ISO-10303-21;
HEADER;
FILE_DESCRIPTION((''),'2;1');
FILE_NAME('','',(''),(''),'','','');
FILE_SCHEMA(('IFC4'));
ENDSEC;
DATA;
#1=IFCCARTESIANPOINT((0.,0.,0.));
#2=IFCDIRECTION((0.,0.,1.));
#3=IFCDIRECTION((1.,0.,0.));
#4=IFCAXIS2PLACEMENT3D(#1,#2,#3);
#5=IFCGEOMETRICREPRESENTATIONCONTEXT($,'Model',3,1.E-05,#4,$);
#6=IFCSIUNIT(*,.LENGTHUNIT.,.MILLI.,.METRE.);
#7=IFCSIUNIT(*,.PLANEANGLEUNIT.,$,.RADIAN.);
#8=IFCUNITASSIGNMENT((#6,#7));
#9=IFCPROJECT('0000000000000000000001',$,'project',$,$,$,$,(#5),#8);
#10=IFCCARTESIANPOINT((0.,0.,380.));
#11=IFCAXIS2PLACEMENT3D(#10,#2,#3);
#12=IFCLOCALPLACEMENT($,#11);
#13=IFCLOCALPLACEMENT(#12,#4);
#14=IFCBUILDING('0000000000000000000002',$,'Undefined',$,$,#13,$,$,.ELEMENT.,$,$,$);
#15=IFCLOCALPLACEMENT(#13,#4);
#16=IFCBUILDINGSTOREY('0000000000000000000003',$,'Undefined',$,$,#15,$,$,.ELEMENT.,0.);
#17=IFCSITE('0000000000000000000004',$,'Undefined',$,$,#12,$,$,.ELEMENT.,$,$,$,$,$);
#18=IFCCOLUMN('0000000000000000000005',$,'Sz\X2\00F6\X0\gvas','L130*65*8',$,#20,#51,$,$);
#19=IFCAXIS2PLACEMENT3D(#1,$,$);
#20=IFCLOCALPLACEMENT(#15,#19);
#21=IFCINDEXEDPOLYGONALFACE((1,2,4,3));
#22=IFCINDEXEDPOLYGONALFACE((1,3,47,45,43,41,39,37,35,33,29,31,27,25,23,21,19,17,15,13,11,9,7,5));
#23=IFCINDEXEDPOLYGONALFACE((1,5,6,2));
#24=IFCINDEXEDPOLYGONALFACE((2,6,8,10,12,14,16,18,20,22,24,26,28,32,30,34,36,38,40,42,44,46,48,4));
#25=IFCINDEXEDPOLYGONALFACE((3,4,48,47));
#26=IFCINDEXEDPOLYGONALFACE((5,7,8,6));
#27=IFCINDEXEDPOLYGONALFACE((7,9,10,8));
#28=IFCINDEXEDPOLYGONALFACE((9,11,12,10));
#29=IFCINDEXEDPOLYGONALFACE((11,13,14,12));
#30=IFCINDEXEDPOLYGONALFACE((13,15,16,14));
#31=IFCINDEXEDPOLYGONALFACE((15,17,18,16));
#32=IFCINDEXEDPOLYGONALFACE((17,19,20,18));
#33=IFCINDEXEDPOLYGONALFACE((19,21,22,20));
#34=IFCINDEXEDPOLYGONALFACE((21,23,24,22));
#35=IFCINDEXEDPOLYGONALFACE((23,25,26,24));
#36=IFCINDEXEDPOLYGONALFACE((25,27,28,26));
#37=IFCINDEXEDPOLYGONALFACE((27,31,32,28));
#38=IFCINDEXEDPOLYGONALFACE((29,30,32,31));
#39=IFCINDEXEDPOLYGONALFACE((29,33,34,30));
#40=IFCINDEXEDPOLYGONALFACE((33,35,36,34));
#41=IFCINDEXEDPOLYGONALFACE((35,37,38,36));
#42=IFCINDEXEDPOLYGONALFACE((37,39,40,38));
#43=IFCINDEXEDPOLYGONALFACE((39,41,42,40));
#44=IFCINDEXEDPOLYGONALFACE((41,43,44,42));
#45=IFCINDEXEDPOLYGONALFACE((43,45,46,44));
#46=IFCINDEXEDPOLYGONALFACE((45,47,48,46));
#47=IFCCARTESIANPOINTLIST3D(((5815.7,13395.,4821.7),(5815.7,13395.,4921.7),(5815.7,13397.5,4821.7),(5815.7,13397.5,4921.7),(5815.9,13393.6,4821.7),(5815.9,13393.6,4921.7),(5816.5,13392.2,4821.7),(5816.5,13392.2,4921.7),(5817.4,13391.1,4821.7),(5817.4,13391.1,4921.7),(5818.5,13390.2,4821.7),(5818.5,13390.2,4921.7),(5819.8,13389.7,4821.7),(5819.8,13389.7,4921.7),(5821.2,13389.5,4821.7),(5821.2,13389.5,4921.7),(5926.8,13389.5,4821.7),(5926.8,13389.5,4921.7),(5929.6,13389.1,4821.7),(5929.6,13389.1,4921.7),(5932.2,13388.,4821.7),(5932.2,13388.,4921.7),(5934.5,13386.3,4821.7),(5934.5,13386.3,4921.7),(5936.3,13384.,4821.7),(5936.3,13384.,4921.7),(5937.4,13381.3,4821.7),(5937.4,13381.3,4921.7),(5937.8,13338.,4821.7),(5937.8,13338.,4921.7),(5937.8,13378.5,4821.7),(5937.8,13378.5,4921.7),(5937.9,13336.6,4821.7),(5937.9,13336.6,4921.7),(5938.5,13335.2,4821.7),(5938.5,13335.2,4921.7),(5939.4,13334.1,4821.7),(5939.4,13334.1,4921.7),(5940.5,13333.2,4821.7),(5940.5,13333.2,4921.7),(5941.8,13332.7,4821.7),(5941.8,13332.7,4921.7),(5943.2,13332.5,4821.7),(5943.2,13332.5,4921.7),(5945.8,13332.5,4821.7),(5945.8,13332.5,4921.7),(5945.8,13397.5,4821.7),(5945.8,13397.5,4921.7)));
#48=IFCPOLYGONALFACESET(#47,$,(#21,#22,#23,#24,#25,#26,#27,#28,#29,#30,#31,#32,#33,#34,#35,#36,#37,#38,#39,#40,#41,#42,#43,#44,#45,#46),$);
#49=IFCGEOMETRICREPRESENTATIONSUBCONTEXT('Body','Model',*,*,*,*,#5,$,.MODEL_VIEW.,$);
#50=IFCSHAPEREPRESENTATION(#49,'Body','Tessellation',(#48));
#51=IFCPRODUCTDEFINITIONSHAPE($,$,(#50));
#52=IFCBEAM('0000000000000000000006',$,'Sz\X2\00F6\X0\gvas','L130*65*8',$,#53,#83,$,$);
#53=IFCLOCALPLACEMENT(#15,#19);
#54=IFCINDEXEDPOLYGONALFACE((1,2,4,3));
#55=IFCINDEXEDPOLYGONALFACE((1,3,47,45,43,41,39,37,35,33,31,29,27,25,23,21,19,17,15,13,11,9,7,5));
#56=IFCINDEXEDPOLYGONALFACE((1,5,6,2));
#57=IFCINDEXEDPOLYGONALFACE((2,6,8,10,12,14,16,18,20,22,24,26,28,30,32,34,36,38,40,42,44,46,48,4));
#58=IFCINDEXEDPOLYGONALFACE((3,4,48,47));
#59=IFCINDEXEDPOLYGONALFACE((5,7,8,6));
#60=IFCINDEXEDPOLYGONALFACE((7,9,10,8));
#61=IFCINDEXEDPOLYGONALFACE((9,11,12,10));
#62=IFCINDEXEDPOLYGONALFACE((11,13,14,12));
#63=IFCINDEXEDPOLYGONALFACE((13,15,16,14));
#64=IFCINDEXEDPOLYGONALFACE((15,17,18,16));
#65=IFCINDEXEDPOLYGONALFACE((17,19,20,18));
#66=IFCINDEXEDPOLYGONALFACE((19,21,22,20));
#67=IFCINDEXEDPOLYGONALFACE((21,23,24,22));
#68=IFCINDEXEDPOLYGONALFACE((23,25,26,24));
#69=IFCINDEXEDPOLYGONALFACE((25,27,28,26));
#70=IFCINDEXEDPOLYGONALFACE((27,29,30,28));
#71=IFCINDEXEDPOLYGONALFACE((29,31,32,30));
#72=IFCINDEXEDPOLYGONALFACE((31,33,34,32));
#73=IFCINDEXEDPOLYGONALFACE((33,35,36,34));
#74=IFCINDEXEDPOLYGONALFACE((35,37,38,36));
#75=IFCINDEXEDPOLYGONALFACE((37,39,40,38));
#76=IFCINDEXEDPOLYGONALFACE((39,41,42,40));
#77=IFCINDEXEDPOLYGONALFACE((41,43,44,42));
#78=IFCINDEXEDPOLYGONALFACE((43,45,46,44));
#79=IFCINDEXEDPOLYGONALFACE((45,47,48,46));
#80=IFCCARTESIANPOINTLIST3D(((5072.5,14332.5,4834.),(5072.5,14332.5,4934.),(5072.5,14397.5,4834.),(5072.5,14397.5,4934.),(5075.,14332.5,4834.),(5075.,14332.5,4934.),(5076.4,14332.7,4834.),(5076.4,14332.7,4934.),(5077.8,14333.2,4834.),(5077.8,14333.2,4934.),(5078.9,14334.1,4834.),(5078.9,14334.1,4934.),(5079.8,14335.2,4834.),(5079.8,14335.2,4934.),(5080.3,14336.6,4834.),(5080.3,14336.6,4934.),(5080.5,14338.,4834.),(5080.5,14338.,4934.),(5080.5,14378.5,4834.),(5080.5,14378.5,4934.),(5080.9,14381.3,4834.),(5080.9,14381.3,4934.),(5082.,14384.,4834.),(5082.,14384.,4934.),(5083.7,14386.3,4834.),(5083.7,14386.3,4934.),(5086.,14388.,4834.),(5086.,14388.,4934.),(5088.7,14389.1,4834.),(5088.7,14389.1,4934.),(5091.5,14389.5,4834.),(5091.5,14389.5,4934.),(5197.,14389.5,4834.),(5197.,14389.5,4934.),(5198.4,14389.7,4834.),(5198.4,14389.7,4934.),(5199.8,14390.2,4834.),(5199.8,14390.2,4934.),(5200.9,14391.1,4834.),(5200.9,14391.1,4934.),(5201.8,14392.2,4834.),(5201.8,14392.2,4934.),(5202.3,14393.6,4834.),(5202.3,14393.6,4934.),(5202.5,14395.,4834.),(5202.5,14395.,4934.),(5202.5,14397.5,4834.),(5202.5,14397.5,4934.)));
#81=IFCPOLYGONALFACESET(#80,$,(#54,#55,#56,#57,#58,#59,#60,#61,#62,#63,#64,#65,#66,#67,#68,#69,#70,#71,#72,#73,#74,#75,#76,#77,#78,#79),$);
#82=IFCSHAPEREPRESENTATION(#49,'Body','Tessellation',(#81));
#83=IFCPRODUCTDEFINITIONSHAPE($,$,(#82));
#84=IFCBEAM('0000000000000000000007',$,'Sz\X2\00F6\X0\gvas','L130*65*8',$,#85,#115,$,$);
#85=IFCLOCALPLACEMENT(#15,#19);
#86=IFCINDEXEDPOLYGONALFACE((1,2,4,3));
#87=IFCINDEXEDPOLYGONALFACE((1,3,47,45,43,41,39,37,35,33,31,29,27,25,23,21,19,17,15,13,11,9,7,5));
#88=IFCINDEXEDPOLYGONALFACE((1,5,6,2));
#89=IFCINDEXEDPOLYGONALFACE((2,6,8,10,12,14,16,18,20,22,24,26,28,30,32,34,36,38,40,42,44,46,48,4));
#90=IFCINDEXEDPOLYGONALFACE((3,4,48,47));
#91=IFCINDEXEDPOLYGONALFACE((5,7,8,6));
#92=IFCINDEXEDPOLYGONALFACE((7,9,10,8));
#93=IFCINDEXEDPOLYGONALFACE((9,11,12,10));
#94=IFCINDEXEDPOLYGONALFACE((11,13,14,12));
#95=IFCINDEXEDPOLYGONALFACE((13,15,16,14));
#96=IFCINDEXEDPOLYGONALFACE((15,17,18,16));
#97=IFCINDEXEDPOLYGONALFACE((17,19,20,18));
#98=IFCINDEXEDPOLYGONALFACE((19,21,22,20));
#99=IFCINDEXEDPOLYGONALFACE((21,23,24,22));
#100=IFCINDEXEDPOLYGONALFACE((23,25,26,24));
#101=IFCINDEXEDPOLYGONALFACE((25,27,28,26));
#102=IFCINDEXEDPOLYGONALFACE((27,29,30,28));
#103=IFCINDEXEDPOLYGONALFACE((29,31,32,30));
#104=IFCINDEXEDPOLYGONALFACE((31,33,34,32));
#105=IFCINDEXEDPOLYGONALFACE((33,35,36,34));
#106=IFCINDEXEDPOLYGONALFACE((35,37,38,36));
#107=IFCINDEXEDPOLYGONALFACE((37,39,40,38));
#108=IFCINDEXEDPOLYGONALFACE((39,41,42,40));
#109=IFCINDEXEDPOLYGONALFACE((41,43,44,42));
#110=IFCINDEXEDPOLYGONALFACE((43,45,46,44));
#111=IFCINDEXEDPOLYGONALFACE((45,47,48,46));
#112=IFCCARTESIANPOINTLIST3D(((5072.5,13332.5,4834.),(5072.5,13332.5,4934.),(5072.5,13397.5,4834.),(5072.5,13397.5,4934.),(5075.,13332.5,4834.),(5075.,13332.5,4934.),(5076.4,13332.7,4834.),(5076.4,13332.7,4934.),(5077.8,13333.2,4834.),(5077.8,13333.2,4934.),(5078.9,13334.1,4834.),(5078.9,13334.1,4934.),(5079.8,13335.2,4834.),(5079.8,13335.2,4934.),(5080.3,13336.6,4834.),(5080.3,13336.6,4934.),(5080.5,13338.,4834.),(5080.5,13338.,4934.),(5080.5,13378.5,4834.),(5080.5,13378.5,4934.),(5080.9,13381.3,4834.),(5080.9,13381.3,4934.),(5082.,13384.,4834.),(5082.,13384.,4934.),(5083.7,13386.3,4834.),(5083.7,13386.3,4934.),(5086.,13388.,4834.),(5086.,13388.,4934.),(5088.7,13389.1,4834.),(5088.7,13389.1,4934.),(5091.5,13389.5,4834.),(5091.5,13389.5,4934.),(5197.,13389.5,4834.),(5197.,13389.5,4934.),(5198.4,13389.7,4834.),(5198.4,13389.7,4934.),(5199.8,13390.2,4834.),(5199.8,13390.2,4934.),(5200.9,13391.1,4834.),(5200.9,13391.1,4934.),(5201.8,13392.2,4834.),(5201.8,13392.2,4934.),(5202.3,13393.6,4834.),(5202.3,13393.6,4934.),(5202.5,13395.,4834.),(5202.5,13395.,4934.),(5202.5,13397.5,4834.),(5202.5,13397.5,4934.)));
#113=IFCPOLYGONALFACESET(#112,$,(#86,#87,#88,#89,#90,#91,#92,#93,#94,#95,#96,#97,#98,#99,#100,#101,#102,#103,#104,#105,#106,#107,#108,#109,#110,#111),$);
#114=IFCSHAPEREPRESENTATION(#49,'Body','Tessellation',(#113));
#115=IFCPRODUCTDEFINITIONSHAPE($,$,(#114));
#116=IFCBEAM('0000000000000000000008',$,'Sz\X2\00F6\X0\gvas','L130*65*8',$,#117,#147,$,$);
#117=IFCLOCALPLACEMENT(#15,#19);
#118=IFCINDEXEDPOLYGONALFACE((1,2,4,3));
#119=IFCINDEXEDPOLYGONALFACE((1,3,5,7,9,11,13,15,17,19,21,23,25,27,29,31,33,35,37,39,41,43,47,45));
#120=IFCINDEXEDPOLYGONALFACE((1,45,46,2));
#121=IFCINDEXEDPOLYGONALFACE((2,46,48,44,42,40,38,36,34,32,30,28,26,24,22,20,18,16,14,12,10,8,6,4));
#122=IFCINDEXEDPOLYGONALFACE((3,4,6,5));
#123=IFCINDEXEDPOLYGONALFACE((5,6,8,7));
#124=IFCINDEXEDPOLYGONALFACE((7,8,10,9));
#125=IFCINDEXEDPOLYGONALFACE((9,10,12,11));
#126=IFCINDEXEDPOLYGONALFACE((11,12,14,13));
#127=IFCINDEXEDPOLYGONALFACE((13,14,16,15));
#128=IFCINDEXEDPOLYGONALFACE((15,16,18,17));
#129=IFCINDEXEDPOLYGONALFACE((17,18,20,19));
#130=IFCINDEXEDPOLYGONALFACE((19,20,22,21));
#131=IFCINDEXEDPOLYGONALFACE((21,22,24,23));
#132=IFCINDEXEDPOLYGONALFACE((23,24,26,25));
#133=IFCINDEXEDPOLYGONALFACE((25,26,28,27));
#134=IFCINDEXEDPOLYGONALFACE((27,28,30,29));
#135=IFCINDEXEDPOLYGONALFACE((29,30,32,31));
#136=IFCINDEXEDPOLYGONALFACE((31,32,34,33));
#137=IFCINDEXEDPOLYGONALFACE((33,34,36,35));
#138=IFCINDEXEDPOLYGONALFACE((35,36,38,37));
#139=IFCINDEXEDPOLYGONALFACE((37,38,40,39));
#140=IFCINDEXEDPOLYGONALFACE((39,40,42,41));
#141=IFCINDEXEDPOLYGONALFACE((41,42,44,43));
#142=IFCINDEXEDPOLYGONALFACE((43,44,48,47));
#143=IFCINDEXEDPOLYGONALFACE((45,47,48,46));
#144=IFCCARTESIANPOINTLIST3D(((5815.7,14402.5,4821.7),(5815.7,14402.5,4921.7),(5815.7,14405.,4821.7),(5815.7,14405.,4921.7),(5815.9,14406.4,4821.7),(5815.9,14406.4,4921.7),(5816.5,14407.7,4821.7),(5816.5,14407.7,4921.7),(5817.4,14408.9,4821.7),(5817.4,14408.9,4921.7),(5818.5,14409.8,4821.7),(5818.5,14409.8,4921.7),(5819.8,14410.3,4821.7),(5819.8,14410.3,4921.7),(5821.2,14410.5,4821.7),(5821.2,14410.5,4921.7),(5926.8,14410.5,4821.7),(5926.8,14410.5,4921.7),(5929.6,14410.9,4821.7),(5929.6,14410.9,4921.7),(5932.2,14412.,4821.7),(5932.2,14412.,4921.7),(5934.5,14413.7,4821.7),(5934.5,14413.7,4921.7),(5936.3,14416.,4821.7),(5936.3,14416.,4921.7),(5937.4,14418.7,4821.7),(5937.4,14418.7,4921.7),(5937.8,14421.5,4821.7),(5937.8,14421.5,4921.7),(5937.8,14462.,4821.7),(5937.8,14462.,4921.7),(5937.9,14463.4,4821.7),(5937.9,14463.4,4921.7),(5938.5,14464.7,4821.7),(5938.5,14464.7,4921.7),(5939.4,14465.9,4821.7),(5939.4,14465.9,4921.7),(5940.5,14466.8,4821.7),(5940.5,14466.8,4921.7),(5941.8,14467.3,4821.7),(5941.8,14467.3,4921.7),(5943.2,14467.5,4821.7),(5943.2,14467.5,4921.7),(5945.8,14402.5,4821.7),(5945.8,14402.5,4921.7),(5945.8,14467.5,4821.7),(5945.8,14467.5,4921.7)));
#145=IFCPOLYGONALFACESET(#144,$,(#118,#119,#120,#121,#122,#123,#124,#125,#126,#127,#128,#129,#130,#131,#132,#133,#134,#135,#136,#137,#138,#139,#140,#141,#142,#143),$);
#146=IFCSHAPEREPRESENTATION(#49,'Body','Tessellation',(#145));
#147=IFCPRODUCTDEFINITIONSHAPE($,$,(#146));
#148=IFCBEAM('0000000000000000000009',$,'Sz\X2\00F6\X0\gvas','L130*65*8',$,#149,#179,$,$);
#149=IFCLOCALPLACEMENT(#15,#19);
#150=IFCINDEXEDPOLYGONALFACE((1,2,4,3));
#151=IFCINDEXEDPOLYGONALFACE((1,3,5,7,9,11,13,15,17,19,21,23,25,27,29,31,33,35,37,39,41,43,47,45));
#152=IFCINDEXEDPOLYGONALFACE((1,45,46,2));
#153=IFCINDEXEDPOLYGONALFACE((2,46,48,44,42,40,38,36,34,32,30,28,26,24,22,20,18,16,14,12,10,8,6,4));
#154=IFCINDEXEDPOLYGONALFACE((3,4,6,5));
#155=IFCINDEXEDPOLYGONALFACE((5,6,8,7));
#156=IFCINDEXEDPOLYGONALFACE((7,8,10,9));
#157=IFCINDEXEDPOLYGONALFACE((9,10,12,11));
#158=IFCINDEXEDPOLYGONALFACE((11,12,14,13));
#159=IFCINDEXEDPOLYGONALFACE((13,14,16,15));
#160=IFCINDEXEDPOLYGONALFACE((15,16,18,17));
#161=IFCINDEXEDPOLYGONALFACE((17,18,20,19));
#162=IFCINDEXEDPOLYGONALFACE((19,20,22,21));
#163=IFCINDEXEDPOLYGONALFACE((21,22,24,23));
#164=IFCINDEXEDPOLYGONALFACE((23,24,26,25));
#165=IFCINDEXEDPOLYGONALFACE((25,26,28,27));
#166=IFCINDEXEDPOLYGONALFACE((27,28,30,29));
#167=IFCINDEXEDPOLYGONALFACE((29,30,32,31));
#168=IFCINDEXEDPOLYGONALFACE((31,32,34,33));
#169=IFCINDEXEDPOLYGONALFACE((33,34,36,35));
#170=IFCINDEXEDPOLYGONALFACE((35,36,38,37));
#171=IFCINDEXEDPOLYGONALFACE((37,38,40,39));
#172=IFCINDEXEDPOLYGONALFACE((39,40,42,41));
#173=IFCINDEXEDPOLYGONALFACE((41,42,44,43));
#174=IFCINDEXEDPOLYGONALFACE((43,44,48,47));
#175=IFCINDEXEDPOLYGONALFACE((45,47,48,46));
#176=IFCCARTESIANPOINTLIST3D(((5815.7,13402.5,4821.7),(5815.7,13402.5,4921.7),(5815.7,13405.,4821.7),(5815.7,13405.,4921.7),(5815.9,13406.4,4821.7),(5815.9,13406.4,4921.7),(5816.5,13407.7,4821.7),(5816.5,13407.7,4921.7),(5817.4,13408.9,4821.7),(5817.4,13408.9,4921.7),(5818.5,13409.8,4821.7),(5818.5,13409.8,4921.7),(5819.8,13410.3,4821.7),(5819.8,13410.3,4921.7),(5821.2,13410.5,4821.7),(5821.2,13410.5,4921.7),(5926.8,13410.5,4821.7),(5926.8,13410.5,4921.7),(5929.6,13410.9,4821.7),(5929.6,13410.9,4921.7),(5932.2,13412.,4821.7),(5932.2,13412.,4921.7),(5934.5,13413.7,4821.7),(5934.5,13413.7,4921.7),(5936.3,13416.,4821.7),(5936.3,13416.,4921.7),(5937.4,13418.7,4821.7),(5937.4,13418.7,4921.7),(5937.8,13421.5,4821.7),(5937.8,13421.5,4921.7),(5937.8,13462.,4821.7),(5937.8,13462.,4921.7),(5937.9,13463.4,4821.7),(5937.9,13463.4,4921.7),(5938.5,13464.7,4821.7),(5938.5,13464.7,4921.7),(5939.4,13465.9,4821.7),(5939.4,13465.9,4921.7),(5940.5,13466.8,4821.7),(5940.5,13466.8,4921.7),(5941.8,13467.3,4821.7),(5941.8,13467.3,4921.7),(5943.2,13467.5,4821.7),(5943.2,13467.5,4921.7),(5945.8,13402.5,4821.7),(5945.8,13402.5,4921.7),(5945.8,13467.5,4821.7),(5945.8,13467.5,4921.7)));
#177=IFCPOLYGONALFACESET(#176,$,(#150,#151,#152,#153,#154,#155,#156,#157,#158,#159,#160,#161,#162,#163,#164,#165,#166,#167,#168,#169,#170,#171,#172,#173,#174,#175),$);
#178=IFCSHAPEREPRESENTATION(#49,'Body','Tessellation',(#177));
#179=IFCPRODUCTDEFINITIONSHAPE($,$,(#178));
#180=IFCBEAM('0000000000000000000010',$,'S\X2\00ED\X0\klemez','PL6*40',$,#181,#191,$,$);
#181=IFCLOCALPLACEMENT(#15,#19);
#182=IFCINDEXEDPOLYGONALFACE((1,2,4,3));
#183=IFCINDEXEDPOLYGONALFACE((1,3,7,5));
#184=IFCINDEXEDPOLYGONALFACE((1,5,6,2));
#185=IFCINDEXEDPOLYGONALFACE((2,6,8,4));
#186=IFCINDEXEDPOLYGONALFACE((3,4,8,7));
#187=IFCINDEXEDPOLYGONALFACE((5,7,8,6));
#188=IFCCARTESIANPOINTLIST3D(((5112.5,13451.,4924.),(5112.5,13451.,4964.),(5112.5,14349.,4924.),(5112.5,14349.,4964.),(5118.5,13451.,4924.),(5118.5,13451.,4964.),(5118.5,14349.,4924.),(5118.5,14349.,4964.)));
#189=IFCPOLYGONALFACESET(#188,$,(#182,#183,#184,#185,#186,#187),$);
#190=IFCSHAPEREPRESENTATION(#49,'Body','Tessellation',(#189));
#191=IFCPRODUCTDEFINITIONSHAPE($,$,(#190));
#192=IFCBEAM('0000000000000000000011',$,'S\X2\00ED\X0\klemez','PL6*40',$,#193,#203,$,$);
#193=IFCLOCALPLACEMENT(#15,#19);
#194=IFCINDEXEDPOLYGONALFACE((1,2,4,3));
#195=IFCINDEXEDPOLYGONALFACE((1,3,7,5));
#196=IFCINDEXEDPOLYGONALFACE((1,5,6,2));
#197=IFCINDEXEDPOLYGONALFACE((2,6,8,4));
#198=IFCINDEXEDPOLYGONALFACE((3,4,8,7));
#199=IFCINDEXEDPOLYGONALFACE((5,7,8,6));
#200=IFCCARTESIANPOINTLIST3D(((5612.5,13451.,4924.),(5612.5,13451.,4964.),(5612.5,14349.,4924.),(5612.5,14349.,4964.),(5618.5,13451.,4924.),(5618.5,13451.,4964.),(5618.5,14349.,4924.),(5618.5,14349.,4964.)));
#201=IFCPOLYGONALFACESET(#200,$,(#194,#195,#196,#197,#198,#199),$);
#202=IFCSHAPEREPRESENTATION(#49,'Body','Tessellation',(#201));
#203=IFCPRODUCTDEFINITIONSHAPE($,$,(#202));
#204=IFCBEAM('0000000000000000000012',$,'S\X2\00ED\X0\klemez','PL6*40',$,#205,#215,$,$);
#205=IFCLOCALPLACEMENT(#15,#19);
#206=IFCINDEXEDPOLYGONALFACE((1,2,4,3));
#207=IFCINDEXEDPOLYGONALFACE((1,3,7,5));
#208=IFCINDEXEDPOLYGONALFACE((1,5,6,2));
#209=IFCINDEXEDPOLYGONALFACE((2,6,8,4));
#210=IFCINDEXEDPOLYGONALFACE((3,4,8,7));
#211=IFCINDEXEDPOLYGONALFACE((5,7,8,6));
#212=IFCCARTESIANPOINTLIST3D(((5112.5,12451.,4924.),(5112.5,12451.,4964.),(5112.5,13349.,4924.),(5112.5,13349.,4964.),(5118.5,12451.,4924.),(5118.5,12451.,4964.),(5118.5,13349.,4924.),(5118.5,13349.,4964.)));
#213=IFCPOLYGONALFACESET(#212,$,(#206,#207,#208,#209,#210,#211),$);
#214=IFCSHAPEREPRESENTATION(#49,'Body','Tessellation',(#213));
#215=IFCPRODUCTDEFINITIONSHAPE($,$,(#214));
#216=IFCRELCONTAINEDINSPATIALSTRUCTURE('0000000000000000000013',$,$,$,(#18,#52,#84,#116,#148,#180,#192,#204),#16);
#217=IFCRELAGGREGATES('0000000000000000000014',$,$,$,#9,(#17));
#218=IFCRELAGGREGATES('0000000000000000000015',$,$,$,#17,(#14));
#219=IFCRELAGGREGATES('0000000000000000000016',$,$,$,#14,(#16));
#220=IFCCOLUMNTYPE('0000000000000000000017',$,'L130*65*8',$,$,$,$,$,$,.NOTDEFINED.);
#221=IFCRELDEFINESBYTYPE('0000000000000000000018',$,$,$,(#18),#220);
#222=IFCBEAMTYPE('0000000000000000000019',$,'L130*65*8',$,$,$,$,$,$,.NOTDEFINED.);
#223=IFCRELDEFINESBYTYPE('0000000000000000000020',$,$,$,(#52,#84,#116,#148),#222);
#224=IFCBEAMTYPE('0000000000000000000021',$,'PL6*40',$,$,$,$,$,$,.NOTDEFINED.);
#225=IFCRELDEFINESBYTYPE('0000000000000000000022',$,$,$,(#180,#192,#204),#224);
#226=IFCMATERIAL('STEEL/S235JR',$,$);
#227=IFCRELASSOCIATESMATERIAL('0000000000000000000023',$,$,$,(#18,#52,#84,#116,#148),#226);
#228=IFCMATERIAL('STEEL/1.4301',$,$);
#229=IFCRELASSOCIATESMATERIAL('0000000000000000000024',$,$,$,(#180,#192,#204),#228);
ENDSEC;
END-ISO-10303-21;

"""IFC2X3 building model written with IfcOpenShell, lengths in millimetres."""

from ifc_helpers import new_model, si_unit, frame, origin_with_axes, origin_2d_with_axis, place, context, subcontext, project, spatial, rectangle, l_section, extrude, material, type_object, element, save


model = new_model("IFC2X3")

# Units and contexts
model_context = context("Model", 3, precision=1e-05, world=origin_with_axes())
body_context = subcontext(model_context, "Body", "Model", "MODEL_VIEW")
ifc_project = project(units=[si_unit("LENGTHUNIT", "METRE", prefix="MILLI"), si_unit("PLANEANGLEUNIT", "RADIAN")], contexts=[model_context])

# Site, building, storey
site_placement = place(None, frame((0.0, 0.0, 380.0), z_axis=(0.0, 0.0, 1.0), x_axis=(1.0, 0.0, 0.0)))
site = spatial("IfcSite", under=ifc_project, at=site_placement, Name="Undefined", CompositionType="ELEMENT")
building_placement = place(site_placement, origin_with_axes())
building = spatial("IfcBuilding", under=site, at=building_placement, Name="Undefined", CompositionType="ELEMENT")
storey_placement = place(building_placement, origin_with_axes())
storey = spatial("IfcBuildingStorey", under=building, at=storey_placement, Name="Undefined", CompositionType="ELEMENT", Elevation=0.0)

# Column
ifc_material_1 = material(Name="STEEL/S235JR")
column_type_1 = type_object("IfcColumnType", Name="L130*65*8", PredefinedType="NOTDEFINED")
for number, where, z_axis, x_axis, name in (
    (1, (5880.8, 13365.0, 4821.7), (0.0, 0.0, 1.0), (-1.0, 0.0, 0.0), "Szögvas"),
):
    element("IfcColumn", number, at=place(storey_placement, frame(where, z_axis=z_axis, x_axis=x_axis)), inside=storey, type_object=column_type_1, material=ifc_material_1, Name=name, Description="L130*65*8", context=body_context, shape_type="SweptSolid", body=[
        extrude(l_section(Depth=130.0, Width=65.0, Thickness=8.0, FilletRadius=11.0, EdgeRadius=5.5, at=origin_2d_with_axis()), frame((0.0, 0.0, 100.0), z_axis=(0.0, 0.0, -1.0), x_axis=(0.0, 1.0, 0.0)), (0.0, 0.0, 1.0), 100.0),
    ])

# Beams
beam_type_1 = type_object("IfcBeamType", Name="L130*65*8", PredefinedType="NOTDEFINED")
for number, where, z_axis, x_axis, name in (
    (2, (5137.5, 14365.0, 4934.0), (1.0, 0.0, 0.0), (0.0, 0.0, -1.0), "Szögvas"),
    (3, (5137.5, 13365.0, 4934.0), (1.0, 0.0, 0.0), (0.0, 0.0, -1.0), "Szögvas"),
    (4, (5880.8, 14435.0, 4921.7), (-1.0, 0.0, 0.0), (0.0, 0.0, -1.0), "Szögvas"),
    (5, (5880.8, 13435.0, 4921.7), (-1.0, 0.0, 0.0), (0.0, 0.0, -1.0), "Szögvas"),
):
    element("IfcBeam", number, at=place(storey_placement, frame(where, z_axis=z_axis, x_axis=x_axis)), inside=storey, type_object=beam_type_1, material=ifc_material_1, Name=name, Description="L130*65*8", context=body_context, shape_type="SweptSolid", body=[
        extrude(l_section(Depth=130.0, Width=65.0, Thickness=8.0, FilletRadius=11.0, EdgeRadius=5.5, at=origin_2d_with_axis()), frame((100.0, 0.0, 0.0), z_axis=(-1.0, 0.0, 0.0), x_axis=(0.0, -1.0, 0.0)), (0.0, 0.0, 1.0), 100.0),
    ])
ifc_material_2 = material(Name="STEEL/1.4301")
beam_type_2 = type_object("IfcBeamType", Name="PL6*40", PredefinedType="NOTDEFINED")
for number, where, z_axis, x_axis, name in (
    (6, (5115.5, 14349.0, 4944.0), (0.0, 0.0, 1.0), (0.0, -1.0, 0.0), "Síklemez"),
    (7, (5615.5, 14349.0, 4944.0), (0.0, 0.0, 1.0), (0.0, -1.0, 0.0), "Síklemez"),
    (8, (5115.5, 13349.0, 4944.0), (0.0, 0.0, 1.0), (0.0, -1.0, 0.0), "Síklemez"),
):
    element("IfcBeam", number, at=place(storey_placement, frame(where, z_axis=z_axis, x_axis=x_axis)), inside=storey, type_object=beam_type_2, material=ifc_material_2, Name=name, Description="PL6*40", context=body_context, shape_type="SweptSolid", body=[
        extrude(rectangle(XDim=6.0, YDim=40.0, at=origin_2d_with_axis()), frame((898.0, 0.0, 0.0), z_axis=(-1.0, 0.0, 0.0), x_axis=(0.0, -1.0, 0.0)), (0.0, 0.0, 1.0), 898.0),
    ])

save(model, "model.ifc")
